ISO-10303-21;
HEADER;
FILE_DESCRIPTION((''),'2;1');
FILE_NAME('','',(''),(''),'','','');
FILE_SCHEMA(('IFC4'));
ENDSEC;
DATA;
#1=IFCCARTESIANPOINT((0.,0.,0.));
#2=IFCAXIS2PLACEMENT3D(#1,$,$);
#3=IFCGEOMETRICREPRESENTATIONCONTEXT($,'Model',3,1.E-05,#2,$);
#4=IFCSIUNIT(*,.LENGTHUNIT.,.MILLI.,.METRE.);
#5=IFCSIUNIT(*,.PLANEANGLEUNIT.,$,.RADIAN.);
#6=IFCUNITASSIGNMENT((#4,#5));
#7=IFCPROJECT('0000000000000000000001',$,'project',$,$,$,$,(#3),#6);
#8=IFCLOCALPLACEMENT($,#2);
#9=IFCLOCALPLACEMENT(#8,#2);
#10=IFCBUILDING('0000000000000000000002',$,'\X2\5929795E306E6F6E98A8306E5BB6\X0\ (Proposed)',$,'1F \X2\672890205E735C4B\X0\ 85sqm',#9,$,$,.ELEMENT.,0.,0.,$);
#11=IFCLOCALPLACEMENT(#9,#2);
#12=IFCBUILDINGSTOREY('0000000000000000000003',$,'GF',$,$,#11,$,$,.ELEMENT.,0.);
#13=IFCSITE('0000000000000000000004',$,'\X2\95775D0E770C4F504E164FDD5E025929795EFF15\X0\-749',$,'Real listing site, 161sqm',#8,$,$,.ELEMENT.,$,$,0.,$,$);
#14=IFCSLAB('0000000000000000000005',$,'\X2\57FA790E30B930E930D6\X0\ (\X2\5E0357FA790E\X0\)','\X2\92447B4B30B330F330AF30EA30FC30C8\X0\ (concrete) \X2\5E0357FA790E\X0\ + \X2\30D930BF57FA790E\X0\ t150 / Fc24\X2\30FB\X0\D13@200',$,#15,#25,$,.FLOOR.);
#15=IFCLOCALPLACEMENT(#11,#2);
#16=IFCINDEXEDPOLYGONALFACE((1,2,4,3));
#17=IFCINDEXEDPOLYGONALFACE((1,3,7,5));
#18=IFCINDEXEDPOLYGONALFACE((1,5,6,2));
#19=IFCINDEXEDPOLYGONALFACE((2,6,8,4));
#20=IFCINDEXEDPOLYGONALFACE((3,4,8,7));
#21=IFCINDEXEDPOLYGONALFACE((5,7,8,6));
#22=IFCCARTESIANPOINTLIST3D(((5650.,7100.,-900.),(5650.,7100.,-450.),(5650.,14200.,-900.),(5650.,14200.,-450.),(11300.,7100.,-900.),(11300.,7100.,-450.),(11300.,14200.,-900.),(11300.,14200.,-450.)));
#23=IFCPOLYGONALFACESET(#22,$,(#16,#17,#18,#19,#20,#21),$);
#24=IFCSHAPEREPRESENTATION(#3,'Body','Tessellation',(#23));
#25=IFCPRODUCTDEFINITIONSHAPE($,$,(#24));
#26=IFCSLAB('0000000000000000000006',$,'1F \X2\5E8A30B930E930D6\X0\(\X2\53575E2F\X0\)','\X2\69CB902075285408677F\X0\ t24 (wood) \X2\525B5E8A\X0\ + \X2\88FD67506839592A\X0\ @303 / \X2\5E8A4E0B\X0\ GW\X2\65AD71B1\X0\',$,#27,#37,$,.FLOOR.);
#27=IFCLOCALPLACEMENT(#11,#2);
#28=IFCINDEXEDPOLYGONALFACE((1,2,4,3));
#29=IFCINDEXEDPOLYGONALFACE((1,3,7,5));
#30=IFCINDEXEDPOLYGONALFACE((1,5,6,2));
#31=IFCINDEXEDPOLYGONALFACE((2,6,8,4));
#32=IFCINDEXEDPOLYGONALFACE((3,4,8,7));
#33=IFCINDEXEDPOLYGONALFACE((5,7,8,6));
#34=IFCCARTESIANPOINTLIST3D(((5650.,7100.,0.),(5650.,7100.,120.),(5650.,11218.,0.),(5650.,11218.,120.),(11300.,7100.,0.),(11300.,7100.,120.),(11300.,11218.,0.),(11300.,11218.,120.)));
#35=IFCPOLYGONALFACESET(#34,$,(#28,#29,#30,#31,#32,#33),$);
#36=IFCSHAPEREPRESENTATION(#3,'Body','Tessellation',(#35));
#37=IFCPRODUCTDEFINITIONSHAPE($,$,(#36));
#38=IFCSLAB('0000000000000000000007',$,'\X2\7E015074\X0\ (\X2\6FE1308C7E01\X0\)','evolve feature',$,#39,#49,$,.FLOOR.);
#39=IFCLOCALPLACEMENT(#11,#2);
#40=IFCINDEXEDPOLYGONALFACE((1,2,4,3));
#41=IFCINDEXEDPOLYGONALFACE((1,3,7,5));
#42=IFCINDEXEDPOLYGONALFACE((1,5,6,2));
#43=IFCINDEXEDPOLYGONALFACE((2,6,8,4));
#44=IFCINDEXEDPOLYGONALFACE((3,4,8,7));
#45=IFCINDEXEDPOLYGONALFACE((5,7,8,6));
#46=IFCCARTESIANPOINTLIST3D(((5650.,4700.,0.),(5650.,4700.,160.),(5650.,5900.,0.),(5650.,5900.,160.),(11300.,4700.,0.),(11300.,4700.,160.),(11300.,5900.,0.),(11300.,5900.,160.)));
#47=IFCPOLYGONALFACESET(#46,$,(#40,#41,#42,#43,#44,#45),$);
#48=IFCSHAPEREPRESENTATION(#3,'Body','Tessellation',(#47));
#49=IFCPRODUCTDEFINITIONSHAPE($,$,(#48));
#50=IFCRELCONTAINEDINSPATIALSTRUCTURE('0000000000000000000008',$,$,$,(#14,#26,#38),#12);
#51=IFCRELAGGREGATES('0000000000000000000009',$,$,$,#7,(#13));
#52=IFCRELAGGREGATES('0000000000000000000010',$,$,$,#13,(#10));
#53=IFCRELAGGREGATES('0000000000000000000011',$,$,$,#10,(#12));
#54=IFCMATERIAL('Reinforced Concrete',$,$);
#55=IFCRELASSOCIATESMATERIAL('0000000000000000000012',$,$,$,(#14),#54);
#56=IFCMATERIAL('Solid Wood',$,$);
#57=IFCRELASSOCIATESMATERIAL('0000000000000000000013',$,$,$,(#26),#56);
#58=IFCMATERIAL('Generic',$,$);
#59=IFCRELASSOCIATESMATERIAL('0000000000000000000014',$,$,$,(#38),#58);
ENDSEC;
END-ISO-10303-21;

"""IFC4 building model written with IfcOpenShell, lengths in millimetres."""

from ifc_helpers import new_model, si_unit, frame, frame_2d, origin, place, context, project, spatial, rectangle, extrude, material, element, save


model = new_model("IFC4")

# Units and contexts
model_context = context("Model", 3, precision=1e-05, world=origin())
ifc_project = project(units=[si_unit("LENGTHUNIT", "METRE", prefix="MILLI"), si_unit("PLANEANGLEUNIT", "RADIAN")], contexts=[model_context])

# Site, building, storey
site_placement = place(None, origin())
site = spatial("IfcSite", under=ifc_project, at=site_placement, Name="長崎県佐世保市天神５-749", ObjectType="Real listing site, 161sqm", CompositionType="ELEMENT", RefElevation=0.0)
building_placement = place(site_placement, origin())
building = spatial("IfcBuilding", under=site, at=building_placement, Name="天神の潮風の家 (Proposed)", ObjectType="1F 木造平屋 85sqm", CompositionType="ELEMENT", ElevationOfRefHeight=0.0, ElevationOfTerrain=0.0)
storey_placement = place(building_placement, origin())
storey = spatial("IfcBuildingStorey", under=building, at=storey_placement, Name="GF", CompositionType="ELEMENT", Elevation=0.0)

# Slabs
ifc_material_1 = material(Name="Reinforced Concrete")
slab_1_placement = place(storey_placement, frame((2825.0, 3550.0, -450.0)))
element("IfcSlab", 1, at=slab_1_placement, inside=storey, material=ifc_material_1, Name="基礎スラブ (布基礎)", Description="鉄筋コンクリート (concrete) 布基礎 + ベタ基礎 t150 / Fc24・D13@200", PredefinedType="FLOOR", context=model_context, shape_type="SweptSolid", body=[
    extrude(rectangle(XDim=5650.0, YDim=7100.0, at=frame_2d((2825.0, 3550.0))), frame((2825.0, 3550.0, -450.0)), (0.0, 0.0, 1.0), 450.0),
])
ifc_material_2 = material(Name="Solid Wood")
slab_2_placement = place(storey_placement, frame((2825.0, 3550.0, 0.0)))
element("IfcSlab", 2, at=slab_2_placement, inside=storey, material=ifc_material_2, Name="1F 床スラブ(南帯)", Description="構造用合板 t24 (wood) 剛床 + 製材根太 @303 / 床下 GW断熱", PredefinedType="FLOOR", context=model_context, shape_type="SweptSolid", body=[
    extrude(rectangle(XDim=5650.0, YDim=4118.0, at=frame_2d((2825.0, 2059.0))), frame((2825.0, 3550.0, 0.0)), (0.0, 0.0, 1.0), 120.0),
])
ifc_material_3 = material(Name="Generic")
slab_3_placement = place(storey_placement, frame((2825.0, 2350.0, 0.0)))
element("IfcSlab", 3, at=slab_3_placement, inside=storey, material=ifc_material_3, Name="縁側 (濡れ縁)", Description="evolve feature", PredefinedType="FLOOR", context=model_context, shape_type="SweptSolid", body=[
    extrude(rectangle(XDim=5650.0, YDim=1200.0, at=frame_2d((2825.0, 600.0))), frame((2825.0, 2350.0, 0.0)), (0.0, 0.0, 1.0), 160.0),
])

save(model, "model.ifc")
